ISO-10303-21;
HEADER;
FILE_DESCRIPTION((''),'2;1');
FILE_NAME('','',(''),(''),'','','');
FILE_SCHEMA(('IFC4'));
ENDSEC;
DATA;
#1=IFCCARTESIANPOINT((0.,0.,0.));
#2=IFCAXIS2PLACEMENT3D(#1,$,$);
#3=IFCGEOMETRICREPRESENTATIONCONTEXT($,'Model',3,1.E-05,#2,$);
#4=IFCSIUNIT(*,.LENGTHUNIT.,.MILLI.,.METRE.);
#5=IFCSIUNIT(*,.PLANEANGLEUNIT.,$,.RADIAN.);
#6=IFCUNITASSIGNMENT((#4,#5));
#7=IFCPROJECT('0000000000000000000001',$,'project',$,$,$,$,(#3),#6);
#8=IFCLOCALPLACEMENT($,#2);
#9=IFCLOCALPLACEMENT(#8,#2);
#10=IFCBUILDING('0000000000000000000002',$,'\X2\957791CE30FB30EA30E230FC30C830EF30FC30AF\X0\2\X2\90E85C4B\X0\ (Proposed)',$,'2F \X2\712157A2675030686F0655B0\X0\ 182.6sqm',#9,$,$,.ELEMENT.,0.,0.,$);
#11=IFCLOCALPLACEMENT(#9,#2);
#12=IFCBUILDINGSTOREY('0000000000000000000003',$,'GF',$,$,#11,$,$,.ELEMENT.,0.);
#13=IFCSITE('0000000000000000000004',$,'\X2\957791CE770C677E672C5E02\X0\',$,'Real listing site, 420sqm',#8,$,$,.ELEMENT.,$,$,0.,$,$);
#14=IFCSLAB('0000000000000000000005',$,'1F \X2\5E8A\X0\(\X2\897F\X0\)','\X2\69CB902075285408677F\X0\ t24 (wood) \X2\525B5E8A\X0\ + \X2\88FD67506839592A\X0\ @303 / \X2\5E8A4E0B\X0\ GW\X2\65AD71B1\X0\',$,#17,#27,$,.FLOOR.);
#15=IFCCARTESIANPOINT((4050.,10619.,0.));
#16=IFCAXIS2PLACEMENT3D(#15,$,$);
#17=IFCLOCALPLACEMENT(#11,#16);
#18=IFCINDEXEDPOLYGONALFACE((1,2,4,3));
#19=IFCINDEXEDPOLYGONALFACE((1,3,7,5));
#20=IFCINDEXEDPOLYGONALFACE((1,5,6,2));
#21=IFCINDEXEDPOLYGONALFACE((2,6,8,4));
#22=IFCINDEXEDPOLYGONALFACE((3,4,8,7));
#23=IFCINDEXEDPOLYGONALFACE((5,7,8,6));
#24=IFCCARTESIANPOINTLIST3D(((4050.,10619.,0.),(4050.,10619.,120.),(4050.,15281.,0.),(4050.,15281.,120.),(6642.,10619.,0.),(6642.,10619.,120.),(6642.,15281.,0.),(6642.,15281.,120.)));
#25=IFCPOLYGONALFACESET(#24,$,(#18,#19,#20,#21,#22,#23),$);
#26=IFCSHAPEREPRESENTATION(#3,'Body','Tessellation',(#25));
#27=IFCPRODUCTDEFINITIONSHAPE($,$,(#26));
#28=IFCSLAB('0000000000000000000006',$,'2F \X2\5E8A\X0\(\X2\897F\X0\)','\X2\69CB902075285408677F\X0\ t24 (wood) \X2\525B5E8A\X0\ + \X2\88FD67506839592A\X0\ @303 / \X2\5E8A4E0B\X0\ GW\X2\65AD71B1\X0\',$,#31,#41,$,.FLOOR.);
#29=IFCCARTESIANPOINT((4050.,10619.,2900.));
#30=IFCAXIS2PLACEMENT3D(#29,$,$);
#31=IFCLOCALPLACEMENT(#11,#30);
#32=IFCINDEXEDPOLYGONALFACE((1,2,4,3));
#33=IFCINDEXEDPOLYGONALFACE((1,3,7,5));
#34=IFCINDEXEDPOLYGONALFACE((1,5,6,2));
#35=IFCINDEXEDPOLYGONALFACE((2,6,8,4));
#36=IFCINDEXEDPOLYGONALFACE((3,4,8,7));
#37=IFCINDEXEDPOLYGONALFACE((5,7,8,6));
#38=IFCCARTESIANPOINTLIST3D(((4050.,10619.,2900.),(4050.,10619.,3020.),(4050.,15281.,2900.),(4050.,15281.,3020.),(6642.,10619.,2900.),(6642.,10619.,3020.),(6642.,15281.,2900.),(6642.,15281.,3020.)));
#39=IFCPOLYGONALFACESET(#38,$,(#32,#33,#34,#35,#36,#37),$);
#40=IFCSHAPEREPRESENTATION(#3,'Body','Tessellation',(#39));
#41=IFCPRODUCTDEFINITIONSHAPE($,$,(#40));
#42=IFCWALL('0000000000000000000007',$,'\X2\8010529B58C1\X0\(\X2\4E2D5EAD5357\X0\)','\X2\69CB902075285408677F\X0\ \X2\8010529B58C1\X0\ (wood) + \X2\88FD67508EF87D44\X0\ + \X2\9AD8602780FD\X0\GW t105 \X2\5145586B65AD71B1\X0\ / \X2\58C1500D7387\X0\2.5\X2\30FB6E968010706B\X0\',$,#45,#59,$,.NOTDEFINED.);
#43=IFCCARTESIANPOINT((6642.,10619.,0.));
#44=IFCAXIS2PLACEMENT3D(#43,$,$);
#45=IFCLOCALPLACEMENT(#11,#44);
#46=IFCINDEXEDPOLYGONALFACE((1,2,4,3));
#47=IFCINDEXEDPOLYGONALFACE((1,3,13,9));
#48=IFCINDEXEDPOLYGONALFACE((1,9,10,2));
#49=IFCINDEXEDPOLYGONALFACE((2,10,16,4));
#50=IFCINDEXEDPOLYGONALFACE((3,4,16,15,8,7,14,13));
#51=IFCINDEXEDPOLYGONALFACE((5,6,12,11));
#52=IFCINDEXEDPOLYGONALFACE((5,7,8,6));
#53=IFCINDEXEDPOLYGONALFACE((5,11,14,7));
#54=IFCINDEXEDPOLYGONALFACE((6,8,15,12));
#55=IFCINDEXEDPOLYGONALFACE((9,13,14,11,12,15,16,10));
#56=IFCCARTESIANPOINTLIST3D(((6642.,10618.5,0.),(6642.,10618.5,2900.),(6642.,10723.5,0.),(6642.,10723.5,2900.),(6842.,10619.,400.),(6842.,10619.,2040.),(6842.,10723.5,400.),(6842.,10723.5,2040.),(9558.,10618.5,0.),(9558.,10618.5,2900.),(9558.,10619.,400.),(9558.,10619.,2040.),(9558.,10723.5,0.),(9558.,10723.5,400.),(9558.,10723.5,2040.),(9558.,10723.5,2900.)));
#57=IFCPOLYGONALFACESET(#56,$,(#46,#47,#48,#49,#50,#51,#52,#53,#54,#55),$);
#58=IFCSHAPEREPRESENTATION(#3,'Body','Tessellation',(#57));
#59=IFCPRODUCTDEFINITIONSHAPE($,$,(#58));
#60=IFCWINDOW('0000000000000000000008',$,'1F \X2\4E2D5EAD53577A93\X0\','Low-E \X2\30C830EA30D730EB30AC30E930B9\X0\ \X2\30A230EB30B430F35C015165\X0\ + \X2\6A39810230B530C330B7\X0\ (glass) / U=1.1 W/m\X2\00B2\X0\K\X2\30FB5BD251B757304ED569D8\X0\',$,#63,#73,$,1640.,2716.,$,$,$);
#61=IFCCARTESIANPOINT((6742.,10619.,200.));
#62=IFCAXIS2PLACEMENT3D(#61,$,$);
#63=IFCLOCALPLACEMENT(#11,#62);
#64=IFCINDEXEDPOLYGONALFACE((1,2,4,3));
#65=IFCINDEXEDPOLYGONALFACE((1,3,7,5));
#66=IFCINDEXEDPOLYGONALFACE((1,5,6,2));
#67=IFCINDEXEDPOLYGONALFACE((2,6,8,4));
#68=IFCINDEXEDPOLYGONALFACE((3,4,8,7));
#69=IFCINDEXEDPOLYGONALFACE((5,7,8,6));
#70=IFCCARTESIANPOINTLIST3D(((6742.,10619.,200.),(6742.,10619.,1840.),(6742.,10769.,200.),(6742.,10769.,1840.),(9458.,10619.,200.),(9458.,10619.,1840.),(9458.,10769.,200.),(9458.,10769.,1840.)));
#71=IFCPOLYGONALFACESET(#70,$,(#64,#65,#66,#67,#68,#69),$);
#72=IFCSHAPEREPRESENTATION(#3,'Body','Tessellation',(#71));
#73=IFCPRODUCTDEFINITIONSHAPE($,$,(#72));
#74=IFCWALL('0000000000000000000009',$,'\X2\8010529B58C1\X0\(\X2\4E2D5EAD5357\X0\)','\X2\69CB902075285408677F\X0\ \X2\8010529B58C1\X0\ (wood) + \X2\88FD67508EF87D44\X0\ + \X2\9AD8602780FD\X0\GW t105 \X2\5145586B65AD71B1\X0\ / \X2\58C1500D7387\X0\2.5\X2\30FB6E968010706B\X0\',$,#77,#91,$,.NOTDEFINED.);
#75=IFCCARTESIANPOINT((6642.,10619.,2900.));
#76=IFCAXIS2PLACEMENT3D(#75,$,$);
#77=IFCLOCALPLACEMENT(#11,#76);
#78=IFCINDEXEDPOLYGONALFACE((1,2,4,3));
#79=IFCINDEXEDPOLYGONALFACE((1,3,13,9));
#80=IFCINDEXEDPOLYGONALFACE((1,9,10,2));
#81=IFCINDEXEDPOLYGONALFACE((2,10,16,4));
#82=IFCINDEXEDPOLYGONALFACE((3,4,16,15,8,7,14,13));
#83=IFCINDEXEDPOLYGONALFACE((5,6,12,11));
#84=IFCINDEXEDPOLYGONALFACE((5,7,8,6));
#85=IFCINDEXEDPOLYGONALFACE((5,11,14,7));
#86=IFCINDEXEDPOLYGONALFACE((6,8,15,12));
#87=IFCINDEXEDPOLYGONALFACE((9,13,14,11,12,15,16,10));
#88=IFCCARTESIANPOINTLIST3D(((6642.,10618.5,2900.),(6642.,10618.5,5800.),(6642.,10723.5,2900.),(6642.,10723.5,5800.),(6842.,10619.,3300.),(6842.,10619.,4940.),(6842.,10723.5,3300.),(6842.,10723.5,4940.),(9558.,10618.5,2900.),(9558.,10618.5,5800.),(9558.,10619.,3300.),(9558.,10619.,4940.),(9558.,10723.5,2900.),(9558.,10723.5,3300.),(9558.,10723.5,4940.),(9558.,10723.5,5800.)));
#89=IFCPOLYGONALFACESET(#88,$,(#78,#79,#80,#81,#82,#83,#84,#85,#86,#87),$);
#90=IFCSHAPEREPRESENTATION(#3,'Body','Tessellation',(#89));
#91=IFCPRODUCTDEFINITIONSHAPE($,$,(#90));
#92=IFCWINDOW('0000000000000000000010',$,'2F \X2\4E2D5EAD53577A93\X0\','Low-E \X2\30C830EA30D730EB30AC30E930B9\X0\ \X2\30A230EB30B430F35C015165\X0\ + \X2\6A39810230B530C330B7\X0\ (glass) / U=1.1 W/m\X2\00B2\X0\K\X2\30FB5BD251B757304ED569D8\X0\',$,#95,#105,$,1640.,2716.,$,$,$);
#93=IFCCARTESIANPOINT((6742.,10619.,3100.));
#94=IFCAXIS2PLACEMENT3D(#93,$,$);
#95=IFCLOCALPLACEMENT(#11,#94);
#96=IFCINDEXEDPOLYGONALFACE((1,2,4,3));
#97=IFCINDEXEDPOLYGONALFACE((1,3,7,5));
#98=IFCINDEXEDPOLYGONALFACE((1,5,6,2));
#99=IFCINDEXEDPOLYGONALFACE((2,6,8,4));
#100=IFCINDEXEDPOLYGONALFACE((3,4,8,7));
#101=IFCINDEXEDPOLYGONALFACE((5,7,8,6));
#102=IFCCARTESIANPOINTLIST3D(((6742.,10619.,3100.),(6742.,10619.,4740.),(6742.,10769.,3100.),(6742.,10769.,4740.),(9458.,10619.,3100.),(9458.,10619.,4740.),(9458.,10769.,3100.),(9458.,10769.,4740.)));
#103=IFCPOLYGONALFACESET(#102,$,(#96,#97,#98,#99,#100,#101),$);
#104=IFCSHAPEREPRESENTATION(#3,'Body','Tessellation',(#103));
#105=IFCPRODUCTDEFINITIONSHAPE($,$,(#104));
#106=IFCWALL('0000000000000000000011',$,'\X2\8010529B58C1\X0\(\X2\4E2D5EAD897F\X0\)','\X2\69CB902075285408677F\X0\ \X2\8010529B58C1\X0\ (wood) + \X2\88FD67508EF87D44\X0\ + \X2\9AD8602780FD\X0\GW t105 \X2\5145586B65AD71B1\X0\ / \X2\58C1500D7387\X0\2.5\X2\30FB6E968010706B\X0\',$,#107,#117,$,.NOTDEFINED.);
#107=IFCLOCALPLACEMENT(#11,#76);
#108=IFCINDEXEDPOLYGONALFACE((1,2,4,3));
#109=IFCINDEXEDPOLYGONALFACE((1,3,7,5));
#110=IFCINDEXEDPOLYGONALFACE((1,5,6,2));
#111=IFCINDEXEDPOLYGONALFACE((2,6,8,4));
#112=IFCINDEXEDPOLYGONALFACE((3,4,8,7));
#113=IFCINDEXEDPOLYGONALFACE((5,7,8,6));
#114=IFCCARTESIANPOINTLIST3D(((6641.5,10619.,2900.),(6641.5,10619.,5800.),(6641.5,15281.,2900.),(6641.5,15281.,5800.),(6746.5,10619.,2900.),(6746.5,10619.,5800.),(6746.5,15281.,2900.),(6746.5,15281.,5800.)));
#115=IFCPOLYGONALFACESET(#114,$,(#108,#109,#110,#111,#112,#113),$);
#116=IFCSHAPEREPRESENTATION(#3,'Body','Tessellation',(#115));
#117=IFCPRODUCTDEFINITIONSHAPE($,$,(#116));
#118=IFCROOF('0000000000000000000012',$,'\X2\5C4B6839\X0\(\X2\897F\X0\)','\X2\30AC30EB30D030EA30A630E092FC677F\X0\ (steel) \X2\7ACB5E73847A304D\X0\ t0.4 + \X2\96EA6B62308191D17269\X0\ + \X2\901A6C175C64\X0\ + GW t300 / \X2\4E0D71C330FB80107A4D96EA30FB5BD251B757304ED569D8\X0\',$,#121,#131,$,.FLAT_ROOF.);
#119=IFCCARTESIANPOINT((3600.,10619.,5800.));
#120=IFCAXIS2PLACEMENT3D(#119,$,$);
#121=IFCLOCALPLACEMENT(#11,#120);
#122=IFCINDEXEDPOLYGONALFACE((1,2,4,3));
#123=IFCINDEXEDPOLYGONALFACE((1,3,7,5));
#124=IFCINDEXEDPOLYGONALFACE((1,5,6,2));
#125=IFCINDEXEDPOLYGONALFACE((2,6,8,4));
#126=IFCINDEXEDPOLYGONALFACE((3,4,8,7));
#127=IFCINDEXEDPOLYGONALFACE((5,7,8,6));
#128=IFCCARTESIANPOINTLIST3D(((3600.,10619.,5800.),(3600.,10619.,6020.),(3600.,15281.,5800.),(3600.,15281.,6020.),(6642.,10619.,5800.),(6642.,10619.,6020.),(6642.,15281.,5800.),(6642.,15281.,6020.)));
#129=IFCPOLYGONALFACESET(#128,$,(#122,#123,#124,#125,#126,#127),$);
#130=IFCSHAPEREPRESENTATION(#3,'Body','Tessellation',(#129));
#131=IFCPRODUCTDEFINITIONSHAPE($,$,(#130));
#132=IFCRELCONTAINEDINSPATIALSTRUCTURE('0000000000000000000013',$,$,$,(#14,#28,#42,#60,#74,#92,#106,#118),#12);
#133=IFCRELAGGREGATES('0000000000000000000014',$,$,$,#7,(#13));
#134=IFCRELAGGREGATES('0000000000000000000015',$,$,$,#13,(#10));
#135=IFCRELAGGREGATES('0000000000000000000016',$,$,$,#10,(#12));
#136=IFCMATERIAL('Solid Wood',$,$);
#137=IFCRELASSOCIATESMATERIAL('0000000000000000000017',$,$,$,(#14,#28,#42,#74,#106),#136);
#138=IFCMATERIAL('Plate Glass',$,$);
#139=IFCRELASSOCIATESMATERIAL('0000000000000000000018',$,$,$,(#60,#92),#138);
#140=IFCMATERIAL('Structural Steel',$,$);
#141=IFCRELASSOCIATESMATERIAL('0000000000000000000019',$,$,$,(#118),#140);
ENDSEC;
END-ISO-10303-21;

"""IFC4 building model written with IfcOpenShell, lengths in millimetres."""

from ifc_helpers import new_model, si_unit, frame, frame_2d, origin, place, context, project, spatial, rectangle, extrude, material, element, fill, save


model = new_model("IFC4")

# Units and contexts
model_context = context("Model", 3, precision=1e-05, world=origin())
ifc_project = project(units=[si_unit("LENGTHUNIT", "METRE", prefix="MILLI"), si_unit("PLANEANGLEUNIT", "RADIAN")], contexts=[model_context])

# Site, building, storey
site_placement = place(None, origin())
site = spatial("IfcSite", under=ifc_project, at=site_placement, Name="長野県松本市", ObjectType="Real listing site, 420sqm", CompositionType="ELEMENT", RefElevation=0.0)
building_placement = place(site_placement, origin())
building = spatial("IfcBuilding", under=site, at=building_placement, Name="長野・リモートワーク2部屋 (Proposed)", ObjectType="2F 無垢材と漆喰 182.6sqm", CompositionType="ELEMENT", ElevationOfRefHeight=0.0, ElevationOfTerrain=0.0)
storey_placement = place(building_placement, origin())
storey = spatial("IfcBuildingStorey", under=building, at=storey_placement, Name="GF", CompositionType="ELEMENT", Elevation=0.0)

# Shared definitions
ifc_material_1 = material(Name="Solid Wood")

# Slabs
slab_1_placement = place(storey_placement, frame((4050.0, 10619.0, 0.0)))
element("IfcSlab", 1, at=slab_1_placement, inside=storey, material=ifc_material_1, Name="1F 床(西)", Description="構造用合板 t24 (wood) 剛床 + 製材根太 @303 / 床下 GW断熱", PredefinedType="FLOOR", context=model_context, shape_type="SweptSolid", body=[
    extrude(rectangle(XDim=2592.0, YDim=4662.0, at=frame_2d((1296.0, 2331.0))), frame((4050.0, 10619.0, 0.0)), (0.0, 0.0, 1.0), 120.0),
])
slab_2_placement = place(storey_placement, frame((4050.0, 10619.0, 2900.0)))
element("IfcSlab", 2, at=slab_2_placement, inside=storey, material=ifc_material_1, Name="2F 床(西)", Description="構造用合板 t24 (wood) 剛床 + 製材根太 @303 / 床下 GW断熱", PredefinedType="FLOOR", context=model_context, shape_type="SweptSolid", body=[
    extrude(rectangle(XDim=2592.0, YDim=4662.0, at=frame_2d((1296.0, 2331.0))), frame((4050.0, 10619.0, 2900.0)), (0.0, 0.0, 1.0), 120.0),
])

# Wall, opening, window
wall_1_placement = place(storey_placement, frame((6642.0, 10619.0, 0.0)))
wall_1 = element("IfcWall", 3, at=wall_1_placement, inside=storey, material=ifc_material_1, Name="耐力壁(中庭南)", Description="構造用合板 耐力壁 (wood) + 製材軸組 + 高性能GW t105 充填断熱 / 壁倍率2.5・準耐火", PredefinedType="NOTDEFINED", context=model_context, shape_type="SweptSolid", body=[
    extrude(rectangle(XDim=2916.0, YDim=105.0, at=frame_2d((1458.0, 52.0))), frame((6642.0, 10619.0, 0.0)), (0.0, 0.0, 1.0), 2900.0),
])
opening_1_placement = place(storey_placement, frame((6742.0, 10619.0, 200.0)))
opening_1 = element("IfcOpeningElement", 4, at=opening_1_placement, cuts=wall_1, PredefinedType="NOTDEFINED", context=model_context, shape_type="SweptSolid", body=[
    extrude(rectangle(XDim=2716.0, YDim=150.0, at=frame_2d((1358.0, 75.0))), frame((6742.0, 10619.0, 200.0)), (0.0, 0.0, 1.0), 1640.0),
])
ifc_material_2 = material(Name="Plate Glass")
window_1_placement = place(storey_placement, frame((6742.0, 10619.0, 200.0)))
window_1 = element("IfcWindow", 5, at=window_1_placement, inside=storey, material=ifc_material_2, Name="1F 中庭南窓", Description="Low-E トリプルガラス アルゴン封入 + 樹脂サッシ (glass) / U=1.1 W/m²K・寒冷地仕様", OverallHeight=1640.0, OverallWidth=2716.0, context=model_context, shape_type="SweptSolid", body=[
    extrude(rectangle(XDim=2716.0, YDim=150.0, at=frame_2d((1358.0, 75.0))), frame((6742.0, 10619.0, 200.0)), (0.0, 0.0, 1.0), 1640.0),
])
fill(opening_1, window_1)

# Wall, opening, window
wall_2_placement = place(storey_placement, frame((6642.0, 10619.0, 2900.0)))
wall_2 = element("IfcWall", 6, at=wall_2_placement, inside=storey, material=ifc_material_1, Name="耐力壁(中庭南)", Description="構造用合板 耐力壁 (wood) + 製材軸組 + 高性能GW t105 充填断熱 / 壁倍率2.5・準耐火", PredefinedType="NOTDEFINED", context=model_context, shape_type="SweptSolid", body=[
    extrude(rectangle(XDim=2916.0, YDim=105.0, at=frame_2d((1458.0, 52.0))), frame((6642.0, 10619.0, 2900.0)), (0.0, 0.0, 1.0), 2900.0),
])
opening_2_placement = place(storey_placement, frame((6742.0, 10619.0, 3100.0)))
opening_2 = element("IfcOpeningElement", 7, at=opening_2_placement, cuts=wall_2, PredefinedType="NOTDEFINED", context=model_context, shape_type="SweptSolid", body=[
    extrude(rectangle(XDim=2716.0, YDim=150.0, at=frame_2d((1358.0, 75.0))), frame((6742.0, 10619.0, 3100.0)), (0.0, 0.0, 1.0), 1640.0),
])
window_2_placement = place(storey_placement, frame((6742.0, 10619.0, 3100.0)))
window_2 = element("IfcWindow", 8, at=window_2_placement, inside=storey, material=ifc_material_2, Name="2F 中庭南窓", Description="Low-E トリプルガラス アルゴン封入 + 樹脂サッシ (glass) / U=1.1 W/m²K・寒冷地仕様", OverallHeight=1640.0, OverallWidth=2716.0, context=model_context, shape_type="SweptSolid", body=[
    extrude(rectangle(XDim=2716.0, YDim=150.0, at=frame_2d((1358.0, 75.0))), frame((6742.0, 10619.0, 3100.0)), (0.0, 0.0, 1.0), 1640.0),
])
fill(opening_2, window_2)

# Wall
wall_3_placement = place(storey_placement, frame((6642.0, 10619.0, 2900.0)))
element("IfcWall", 9, at=wall_3_placement, inside=storey, material=ifc_material_1, Name="耐力壁(中庭西)", Description="構造用合板 耐力壁 (wood) + 製材軸組 + 高性能GW t105 充填断熱 / 壁倍率2.5・準耐火", PredefinedType="NOTDEFINED", context=model_context, shape_type="SweptSolid", body=[
    extrude(rectangle(XDim=105.0, YDim=4662.0, at=frame_2d((52.0, 2331.0))), frame((6642.0, 10619.0, 2900.0)), (0.0, 0.0, 1.0), 2900.0),
])

# Roof
ifc_material_3 = material(Name="Structural Steel")
for number, where, name in (
    (10, (3600.0, 10619.0, 5800.0), "屋根(西)"),
):
    element("IfcRoof", number, at=place(storey_placement, frame(where)), inside=storey, material=ifc_material_3, Name=name, Description="ガルバリウム鋼板 (steel) 立平葺き t0.4 + 雪止め金物 + 通気層 + GW t300 / 不燃・耐積雪・寒冷地仕様", PredefinedType="FLAT_ROOF", context=model_context, shape_type="SweptSolid", body=[
        extrude(rectangle(XDim=3042.0, YDim=4662.0, at=frame_2d((1521.0, 2331.0))), frame((3600.0, 10619.0, 5800.0)), (0.0, 0.0, 1.0), 220.0),
    ])

save(model, "model.ifc")
